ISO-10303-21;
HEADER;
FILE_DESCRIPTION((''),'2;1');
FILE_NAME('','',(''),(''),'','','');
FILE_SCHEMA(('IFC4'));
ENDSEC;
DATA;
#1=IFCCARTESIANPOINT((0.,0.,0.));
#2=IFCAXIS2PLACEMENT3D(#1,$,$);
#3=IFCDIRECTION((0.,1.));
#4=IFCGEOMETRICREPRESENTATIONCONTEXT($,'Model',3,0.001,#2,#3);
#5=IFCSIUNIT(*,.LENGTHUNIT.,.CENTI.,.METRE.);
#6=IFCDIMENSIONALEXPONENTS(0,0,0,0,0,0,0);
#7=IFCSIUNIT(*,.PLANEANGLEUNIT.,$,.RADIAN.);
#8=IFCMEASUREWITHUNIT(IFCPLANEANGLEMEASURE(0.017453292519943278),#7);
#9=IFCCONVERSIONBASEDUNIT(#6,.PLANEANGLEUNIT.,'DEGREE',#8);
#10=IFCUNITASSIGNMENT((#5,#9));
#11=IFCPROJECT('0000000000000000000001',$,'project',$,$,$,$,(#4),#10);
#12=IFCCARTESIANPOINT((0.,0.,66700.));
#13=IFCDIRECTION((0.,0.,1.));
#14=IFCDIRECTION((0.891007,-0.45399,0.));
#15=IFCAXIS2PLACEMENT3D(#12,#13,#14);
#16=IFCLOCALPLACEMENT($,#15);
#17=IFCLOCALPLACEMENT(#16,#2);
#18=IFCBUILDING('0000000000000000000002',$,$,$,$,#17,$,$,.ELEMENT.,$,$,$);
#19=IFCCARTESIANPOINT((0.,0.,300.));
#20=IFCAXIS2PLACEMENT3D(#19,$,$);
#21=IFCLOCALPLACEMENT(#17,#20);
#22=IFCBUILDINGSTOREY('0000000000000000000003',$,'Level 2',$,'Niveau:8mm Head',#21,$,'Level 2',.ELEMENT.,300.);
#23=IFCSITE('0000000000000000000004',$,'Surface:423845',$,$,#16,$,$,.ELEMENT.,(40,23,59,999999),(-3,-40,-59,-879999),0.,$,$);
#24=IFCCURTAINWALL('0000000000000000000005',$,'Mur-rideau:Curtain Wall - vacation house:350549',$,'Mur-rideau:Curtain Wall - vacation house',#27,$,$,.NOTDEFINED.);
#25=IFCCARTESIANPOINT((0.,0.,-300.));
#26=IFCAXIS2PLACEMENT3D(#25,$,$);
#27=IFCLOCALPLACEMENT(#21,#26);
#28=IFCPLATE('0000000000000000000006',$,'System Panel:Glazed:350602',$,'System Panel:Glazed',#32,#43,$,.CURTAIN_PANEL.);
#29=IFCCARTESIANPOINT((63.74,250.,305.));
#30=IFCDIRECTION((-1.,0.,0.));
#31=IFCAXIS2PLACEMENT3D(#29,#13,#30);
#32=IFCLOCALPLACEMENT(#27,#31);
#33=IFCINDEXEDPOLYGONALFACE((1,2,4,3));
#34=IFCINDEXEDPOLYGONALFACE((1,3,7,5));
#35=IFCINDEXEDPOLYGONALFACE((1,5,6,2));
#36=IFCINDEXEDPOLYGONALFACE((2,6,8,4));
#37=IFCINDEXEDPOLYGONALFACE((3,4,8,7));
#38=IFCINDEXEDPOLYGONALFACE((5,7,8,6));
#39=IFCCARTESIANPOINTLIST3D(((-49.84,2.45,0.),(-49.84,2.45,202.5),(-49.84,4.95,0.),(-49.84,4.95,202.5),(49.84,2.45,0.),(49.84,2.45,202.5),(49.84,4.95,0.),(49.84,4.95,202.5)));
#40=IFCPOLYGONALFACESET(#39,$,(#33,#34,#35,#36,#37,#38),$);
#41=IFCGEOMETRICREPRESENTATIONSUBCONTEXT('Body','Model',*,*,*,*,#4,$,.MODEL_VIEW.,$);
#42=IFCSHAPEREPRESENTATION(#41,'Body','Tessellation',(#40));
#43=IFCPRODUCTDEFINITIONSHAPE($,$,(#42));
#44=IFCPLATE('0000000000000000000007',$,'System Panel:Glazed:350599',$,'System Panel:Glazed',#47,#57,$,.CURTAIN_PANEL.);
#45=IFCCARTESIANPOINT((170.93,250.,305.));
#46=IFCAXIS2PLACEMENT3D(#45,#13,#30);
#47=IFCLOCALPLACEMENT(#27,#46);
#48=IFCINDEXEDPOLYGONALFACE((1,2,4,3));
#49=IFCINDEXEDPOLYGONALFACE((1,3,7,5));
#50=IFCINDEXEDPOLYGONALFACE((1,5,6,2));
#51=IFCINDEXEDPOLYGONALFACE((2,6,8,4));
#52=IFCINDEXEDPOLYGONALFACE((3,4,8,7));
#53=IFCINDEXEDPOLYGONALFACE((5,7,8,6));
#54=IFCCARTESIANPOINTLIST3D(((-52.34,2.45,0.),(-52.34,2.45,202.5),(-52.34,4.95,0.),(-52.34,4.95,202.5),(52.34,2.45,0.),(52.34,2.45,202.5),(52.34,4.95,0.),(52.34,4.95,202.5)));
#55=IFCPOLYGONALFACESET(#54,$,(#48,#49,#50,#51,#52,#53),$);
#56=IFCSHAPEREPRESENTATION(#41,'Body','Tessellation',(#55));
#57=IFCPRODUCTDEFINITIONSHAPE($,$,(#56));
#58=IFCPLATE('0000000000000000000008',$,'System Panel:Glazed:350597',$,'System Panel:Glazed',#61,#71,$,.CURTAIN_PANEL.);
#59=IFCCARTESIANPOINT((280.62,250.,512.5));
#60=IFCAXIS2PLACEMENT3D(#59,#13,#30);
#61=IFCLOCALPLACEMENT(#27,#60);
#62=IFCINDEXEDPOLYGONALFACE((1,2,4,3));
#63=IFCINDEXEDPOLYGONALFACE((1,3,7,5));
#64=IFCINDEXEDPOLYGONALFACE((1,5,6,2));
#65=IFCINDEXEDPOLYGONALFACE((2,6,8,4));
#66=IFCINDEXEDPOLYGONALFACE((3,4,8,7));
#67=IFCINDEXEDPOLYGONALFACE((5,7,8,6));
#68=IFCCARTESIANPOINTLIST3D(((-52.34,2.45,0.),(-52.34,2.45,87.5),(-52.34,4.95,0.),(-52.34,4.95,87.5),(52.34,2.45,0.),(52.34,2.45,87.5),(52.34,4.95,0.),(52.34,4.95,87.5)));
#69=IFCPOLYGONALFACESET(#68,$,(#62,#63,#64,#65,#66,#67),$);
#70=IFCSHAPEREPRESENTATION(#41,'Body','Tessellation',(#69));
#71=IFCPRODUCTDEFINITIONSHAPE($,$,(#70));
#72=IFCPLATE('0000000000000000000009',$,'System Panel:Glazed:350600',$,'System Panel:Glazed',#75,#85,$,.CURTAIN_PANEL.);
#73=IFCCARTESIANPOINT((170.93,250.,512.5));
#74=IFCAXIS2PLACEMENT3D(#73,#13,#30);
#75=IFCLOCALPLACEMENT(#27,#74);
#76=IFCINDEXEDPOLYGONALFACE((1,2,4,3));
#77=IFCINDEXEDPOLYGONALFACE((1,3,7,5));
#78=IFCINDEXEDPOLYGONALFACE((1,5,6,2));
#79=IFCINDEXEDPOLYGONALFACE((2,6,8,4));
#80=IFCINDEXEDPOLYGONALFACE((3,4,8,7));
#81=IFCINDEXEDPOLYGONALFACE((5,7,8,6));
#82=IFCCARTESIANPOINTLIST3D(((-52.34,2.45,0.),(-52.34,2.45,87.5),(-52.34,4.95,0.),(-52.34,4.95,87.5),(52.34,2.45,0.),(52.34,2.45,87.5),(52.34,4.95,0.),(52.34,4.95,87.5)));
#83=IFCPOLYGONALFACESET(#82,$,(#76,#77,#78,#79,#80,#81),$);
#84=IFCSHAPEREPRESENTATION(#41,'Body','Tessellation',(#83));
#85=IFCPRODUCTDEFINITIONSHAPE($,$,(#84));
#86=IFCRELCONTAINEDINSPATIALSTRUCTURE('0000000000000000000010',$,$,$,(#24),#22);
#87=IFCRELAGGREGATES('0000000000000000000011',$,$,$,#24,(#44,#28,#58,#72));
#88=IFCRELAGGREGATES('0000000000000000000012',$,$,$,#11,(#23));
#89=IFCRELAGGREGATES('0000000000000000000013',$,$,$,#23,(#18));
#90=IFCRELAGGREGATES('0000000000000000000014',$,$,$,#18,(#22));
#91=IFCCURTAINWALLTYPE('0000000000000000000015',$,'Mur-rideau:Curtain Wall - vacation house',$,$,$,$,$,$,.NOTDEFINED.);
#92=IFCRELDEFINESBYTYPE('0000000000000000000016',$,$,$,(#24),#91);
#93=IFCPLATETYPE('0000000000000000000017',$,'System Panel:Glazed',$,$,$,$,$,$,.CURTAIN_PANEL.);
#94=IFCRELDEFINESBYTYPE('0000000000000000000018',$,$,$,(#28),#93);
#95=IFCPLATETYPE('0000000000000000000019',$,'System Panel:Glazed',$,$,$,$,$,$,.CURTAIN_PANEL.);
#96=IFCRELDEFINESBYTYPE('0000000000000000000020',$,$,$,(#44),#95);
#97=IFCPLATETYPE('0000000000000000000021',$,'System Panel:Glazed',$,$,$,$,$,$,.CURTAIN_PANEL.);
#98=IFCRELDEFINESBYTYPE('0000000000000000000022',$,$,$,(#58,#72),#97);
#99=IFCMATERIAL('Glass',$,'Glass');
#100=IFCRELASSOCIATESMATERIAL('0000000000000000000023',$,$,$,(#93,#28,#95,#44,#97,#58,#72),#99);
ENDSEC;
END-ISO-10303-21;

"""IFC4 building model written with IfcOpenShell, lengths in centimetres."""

from ifc_helpers import new_model, entity, si_unit, converted_unit, direction, frame, origin, origin_2d_with_axis, place, context, subcontext, project, spatial, rectangle, extrude, source, transform, mapped, material, type_object, type_shapes, element, aggregate, save


model = new_model("IFC4")

# Units and contexts
model_context = context("Model", 3, precision=0.001, world=origin(), true_north=direction((0.0, 1.0)))
body_context = subcontext(model_context, "Body", "Model", "MODEL_VIEW")
ifc_project = project(units=[si_unit("LENGTHUNIT", "METRE", prefix="CENTI"), converted_unit("PLANEANGLEUNIT", "DEGREE", entity("IfcPlaneAngleMeasure", 0.017453292519943278), si_unit("PLANEANGLEUNIT", "RADIAN"), dimensions=[0, 0, 0, 0, 0, 0, 0])], contexts=[model_context])

# Site, building, storey
site_placement = place(None, frame((0.0, 0.0, 66700.0), z_axis=(0.0, 0.0, 1.0), x_axis=(0.891007, -0.45399, 0.0)))
site = spatial("IfcSite", under=ifc_project, at=site_placement, Name="Surface:423845", CompositionType="ELEMENT", RefLatitude=(40, 23, 59, 999999), RefLongitude=(-3, -40, -59, -879999), RefElevation=0.0)
building_placement = place(site_placement, origin())
building = spatial("IfcBuilding", under=site, at=building_placement, CompositionType="ELEMENT")
storey_placement = place(building_placement, frame((0.0, 0.0, 300.0)))
storey = spatial("IfcBuildingStorey", under=building, at=storey_placement, Name="Level 2", ObjectType="Niveau:8mm Head", LongName="Level 2", CompositionType="ELEMENT", Elevation=300.0)

# Curtain wall, plates
curtain_wall_type = type_object("IfcCurtainWallType", Name="Mur-rideau:Curtain Wall - vacation house", PredefinedType="NOTDEFINED")
curtain_wall_placement = place(storey_placement, frame((0.0, 0.0, -300.0)))
curtain_wall = element("IfcCurtainWall", 1, at=curtain_wall_placement, inside=storey, type_object=curtain_wall_type, Name="Mur-rideau:Curtain Wall - vacation house:350549", ObjectType="Mur-rideau:Curtain Wall - vacation house", PredefinedType="NOTDEFINED")
ifc_material_1 = material(Name="Glass", Category="Glass")
plate_type_1 = type_object("IfcPlateType", Name="System Panel:Glazed", PredefinedType="CURTAIN_PANEL", material=ifc_material_1)
shared_shape_1 = source(origin(), body_context, "Body", "SweptSolid", [
    extrude(rectangle(XDim=2.5, YDim=99.69, at=origin_2d_with_axis()), frame((0.0, 3.7, 0.0), z_axis=(0.0, 0.0, 1.0), x_axis=(0.0, 1.0, 0.0)), (0.0, 0.0, 1.0), 202.5),
])
type_shapes(plate_type_1, [shared_shape_1])
plate_1_placement = place(curtain_wall_placement, frame((63.74, 250.0, 305.0), z_axis=(0.0, 0.0, 1.0), x_axis=(-1.0, 0.0, 0.0)))
plate_1 = element("IfcPlate", 2, at=plate_1_placement, type_object=plate_type_1, material=ifc_material_1, Name="System Panel:Glazed:350602", ObjectType="System Panel:Glazed", PredefinedType="CURTAIN_PANEL", context=body_context, shape_type="MappedRepresentation", body=[
    mapped(shared_shape_1, transform((0.0, 0.0, 0.0), scale=1.0)),
])
plate_type_2 = type_object("IfcPlateType", Name="System Panel:Glazed", PredefinedType="CURTAIN_PANEL", material=ifc_material_1)
shared_shape_2 = source(origin(), body_context, "Body", "SweptSolid", [
    extrude(rectangle(XDim=2.5, YDim=104.69, at=origin_2d_with_axis()), frame((0.0, 3.7, 0.0), z_axis=(0.0, 0.0, 1.0), x_axis=(0.0, 1.0, 0.0)), (0.0, 0.0, 1.0), 202.5),
])
type_shapes(plate_type_2, [shared_shape_2])
plate_2_placement = place(curtain_wall_placement, frame((170.93, 250.0, 305.0), z_axis=(0.0, 0.0, 1.0), x_axis=(-1.0, 0.0, 0.0)))
plate_2 = element("IfcPlate", 3, at=plate_2_placement, type_object=plate_type_2, material=ifc_material_1, Name="System Panel:Glazed:350599", ObjectType="System Panel:Glazed", PredefinedType="CURTAIN_PANEL", context=body_context, shape_type="MappedRepresentation", body=[
    mapped(shared_shape_2, transform((0.0, 0.0, 0.0), scale=1.0)),
])
plate_type_3 = type_object("IfcPlateType", Name="System Panel:Glazed", PredefinedType="CURTAIN_PANEL", material=ifc_material_1)
shared_shape_3 = source(origin(), body_context, "Body", "SweptSolid", [
    extrude(rectangle(XDim=2.5, YDim=104.69, at=origin_2d_with_axis()), frame((0.0, 3.7, 0.0), z_axis=(0.0, 0.0, 1.0), x_axis=(0.0, 1.0, 0.0)), (0.0, 0.0, 1.0), 87.5),
])
type_shapes(plate_type_3, [shared_shape_3])
plate_3_placement = place(curtain_wall_placement, frame((280.62, 250.0, 512.5), z_axis=(0.0, 0.0, 1.0), x_axis=(-1.0, 0.0, 0.0)))
plate_3 = element("IfcPlate", 4, at=plate_3_placement, type_object=plate_type_3, material=ifc_material_1, Name="System Panel:Glazed:350597", ObjectType="System Panel:Glazed", PredefinedType="CURTAIN_PANEL", context=body_context, shape_type="MappedRepresentation", body=[
    mapped(shared_shape_3, transform((0.0, 0.0, 0.0), scale=1.0)),
])
plate_4_placement = place(curtain_wall_placement, frame((170.93, 250.0, 512.5), z_axis=(0.0, 0.0, 1.0), x_axis=(-1.0, 0.0, 0.0)))
plate_4 = element("IfcPlate", 5, at=plate_4_placement, type_object=plate_type_3, material=ifc_material_1, Name="System Panel:Glazed:350600", ObjectType="System Panel:Glazed", PredefinedType="CURTAIN_PANEL", context=body_context, shape_type="MappedRepresentation", body=[
    mapped(shared_shape_3, transform((0.0, 0.0, 0.0), scale=1.0)),
])
aggregate(curtain_wall, [plate_2, plate_1, plate_3, plate_4])

save(model, "model.ifc")
